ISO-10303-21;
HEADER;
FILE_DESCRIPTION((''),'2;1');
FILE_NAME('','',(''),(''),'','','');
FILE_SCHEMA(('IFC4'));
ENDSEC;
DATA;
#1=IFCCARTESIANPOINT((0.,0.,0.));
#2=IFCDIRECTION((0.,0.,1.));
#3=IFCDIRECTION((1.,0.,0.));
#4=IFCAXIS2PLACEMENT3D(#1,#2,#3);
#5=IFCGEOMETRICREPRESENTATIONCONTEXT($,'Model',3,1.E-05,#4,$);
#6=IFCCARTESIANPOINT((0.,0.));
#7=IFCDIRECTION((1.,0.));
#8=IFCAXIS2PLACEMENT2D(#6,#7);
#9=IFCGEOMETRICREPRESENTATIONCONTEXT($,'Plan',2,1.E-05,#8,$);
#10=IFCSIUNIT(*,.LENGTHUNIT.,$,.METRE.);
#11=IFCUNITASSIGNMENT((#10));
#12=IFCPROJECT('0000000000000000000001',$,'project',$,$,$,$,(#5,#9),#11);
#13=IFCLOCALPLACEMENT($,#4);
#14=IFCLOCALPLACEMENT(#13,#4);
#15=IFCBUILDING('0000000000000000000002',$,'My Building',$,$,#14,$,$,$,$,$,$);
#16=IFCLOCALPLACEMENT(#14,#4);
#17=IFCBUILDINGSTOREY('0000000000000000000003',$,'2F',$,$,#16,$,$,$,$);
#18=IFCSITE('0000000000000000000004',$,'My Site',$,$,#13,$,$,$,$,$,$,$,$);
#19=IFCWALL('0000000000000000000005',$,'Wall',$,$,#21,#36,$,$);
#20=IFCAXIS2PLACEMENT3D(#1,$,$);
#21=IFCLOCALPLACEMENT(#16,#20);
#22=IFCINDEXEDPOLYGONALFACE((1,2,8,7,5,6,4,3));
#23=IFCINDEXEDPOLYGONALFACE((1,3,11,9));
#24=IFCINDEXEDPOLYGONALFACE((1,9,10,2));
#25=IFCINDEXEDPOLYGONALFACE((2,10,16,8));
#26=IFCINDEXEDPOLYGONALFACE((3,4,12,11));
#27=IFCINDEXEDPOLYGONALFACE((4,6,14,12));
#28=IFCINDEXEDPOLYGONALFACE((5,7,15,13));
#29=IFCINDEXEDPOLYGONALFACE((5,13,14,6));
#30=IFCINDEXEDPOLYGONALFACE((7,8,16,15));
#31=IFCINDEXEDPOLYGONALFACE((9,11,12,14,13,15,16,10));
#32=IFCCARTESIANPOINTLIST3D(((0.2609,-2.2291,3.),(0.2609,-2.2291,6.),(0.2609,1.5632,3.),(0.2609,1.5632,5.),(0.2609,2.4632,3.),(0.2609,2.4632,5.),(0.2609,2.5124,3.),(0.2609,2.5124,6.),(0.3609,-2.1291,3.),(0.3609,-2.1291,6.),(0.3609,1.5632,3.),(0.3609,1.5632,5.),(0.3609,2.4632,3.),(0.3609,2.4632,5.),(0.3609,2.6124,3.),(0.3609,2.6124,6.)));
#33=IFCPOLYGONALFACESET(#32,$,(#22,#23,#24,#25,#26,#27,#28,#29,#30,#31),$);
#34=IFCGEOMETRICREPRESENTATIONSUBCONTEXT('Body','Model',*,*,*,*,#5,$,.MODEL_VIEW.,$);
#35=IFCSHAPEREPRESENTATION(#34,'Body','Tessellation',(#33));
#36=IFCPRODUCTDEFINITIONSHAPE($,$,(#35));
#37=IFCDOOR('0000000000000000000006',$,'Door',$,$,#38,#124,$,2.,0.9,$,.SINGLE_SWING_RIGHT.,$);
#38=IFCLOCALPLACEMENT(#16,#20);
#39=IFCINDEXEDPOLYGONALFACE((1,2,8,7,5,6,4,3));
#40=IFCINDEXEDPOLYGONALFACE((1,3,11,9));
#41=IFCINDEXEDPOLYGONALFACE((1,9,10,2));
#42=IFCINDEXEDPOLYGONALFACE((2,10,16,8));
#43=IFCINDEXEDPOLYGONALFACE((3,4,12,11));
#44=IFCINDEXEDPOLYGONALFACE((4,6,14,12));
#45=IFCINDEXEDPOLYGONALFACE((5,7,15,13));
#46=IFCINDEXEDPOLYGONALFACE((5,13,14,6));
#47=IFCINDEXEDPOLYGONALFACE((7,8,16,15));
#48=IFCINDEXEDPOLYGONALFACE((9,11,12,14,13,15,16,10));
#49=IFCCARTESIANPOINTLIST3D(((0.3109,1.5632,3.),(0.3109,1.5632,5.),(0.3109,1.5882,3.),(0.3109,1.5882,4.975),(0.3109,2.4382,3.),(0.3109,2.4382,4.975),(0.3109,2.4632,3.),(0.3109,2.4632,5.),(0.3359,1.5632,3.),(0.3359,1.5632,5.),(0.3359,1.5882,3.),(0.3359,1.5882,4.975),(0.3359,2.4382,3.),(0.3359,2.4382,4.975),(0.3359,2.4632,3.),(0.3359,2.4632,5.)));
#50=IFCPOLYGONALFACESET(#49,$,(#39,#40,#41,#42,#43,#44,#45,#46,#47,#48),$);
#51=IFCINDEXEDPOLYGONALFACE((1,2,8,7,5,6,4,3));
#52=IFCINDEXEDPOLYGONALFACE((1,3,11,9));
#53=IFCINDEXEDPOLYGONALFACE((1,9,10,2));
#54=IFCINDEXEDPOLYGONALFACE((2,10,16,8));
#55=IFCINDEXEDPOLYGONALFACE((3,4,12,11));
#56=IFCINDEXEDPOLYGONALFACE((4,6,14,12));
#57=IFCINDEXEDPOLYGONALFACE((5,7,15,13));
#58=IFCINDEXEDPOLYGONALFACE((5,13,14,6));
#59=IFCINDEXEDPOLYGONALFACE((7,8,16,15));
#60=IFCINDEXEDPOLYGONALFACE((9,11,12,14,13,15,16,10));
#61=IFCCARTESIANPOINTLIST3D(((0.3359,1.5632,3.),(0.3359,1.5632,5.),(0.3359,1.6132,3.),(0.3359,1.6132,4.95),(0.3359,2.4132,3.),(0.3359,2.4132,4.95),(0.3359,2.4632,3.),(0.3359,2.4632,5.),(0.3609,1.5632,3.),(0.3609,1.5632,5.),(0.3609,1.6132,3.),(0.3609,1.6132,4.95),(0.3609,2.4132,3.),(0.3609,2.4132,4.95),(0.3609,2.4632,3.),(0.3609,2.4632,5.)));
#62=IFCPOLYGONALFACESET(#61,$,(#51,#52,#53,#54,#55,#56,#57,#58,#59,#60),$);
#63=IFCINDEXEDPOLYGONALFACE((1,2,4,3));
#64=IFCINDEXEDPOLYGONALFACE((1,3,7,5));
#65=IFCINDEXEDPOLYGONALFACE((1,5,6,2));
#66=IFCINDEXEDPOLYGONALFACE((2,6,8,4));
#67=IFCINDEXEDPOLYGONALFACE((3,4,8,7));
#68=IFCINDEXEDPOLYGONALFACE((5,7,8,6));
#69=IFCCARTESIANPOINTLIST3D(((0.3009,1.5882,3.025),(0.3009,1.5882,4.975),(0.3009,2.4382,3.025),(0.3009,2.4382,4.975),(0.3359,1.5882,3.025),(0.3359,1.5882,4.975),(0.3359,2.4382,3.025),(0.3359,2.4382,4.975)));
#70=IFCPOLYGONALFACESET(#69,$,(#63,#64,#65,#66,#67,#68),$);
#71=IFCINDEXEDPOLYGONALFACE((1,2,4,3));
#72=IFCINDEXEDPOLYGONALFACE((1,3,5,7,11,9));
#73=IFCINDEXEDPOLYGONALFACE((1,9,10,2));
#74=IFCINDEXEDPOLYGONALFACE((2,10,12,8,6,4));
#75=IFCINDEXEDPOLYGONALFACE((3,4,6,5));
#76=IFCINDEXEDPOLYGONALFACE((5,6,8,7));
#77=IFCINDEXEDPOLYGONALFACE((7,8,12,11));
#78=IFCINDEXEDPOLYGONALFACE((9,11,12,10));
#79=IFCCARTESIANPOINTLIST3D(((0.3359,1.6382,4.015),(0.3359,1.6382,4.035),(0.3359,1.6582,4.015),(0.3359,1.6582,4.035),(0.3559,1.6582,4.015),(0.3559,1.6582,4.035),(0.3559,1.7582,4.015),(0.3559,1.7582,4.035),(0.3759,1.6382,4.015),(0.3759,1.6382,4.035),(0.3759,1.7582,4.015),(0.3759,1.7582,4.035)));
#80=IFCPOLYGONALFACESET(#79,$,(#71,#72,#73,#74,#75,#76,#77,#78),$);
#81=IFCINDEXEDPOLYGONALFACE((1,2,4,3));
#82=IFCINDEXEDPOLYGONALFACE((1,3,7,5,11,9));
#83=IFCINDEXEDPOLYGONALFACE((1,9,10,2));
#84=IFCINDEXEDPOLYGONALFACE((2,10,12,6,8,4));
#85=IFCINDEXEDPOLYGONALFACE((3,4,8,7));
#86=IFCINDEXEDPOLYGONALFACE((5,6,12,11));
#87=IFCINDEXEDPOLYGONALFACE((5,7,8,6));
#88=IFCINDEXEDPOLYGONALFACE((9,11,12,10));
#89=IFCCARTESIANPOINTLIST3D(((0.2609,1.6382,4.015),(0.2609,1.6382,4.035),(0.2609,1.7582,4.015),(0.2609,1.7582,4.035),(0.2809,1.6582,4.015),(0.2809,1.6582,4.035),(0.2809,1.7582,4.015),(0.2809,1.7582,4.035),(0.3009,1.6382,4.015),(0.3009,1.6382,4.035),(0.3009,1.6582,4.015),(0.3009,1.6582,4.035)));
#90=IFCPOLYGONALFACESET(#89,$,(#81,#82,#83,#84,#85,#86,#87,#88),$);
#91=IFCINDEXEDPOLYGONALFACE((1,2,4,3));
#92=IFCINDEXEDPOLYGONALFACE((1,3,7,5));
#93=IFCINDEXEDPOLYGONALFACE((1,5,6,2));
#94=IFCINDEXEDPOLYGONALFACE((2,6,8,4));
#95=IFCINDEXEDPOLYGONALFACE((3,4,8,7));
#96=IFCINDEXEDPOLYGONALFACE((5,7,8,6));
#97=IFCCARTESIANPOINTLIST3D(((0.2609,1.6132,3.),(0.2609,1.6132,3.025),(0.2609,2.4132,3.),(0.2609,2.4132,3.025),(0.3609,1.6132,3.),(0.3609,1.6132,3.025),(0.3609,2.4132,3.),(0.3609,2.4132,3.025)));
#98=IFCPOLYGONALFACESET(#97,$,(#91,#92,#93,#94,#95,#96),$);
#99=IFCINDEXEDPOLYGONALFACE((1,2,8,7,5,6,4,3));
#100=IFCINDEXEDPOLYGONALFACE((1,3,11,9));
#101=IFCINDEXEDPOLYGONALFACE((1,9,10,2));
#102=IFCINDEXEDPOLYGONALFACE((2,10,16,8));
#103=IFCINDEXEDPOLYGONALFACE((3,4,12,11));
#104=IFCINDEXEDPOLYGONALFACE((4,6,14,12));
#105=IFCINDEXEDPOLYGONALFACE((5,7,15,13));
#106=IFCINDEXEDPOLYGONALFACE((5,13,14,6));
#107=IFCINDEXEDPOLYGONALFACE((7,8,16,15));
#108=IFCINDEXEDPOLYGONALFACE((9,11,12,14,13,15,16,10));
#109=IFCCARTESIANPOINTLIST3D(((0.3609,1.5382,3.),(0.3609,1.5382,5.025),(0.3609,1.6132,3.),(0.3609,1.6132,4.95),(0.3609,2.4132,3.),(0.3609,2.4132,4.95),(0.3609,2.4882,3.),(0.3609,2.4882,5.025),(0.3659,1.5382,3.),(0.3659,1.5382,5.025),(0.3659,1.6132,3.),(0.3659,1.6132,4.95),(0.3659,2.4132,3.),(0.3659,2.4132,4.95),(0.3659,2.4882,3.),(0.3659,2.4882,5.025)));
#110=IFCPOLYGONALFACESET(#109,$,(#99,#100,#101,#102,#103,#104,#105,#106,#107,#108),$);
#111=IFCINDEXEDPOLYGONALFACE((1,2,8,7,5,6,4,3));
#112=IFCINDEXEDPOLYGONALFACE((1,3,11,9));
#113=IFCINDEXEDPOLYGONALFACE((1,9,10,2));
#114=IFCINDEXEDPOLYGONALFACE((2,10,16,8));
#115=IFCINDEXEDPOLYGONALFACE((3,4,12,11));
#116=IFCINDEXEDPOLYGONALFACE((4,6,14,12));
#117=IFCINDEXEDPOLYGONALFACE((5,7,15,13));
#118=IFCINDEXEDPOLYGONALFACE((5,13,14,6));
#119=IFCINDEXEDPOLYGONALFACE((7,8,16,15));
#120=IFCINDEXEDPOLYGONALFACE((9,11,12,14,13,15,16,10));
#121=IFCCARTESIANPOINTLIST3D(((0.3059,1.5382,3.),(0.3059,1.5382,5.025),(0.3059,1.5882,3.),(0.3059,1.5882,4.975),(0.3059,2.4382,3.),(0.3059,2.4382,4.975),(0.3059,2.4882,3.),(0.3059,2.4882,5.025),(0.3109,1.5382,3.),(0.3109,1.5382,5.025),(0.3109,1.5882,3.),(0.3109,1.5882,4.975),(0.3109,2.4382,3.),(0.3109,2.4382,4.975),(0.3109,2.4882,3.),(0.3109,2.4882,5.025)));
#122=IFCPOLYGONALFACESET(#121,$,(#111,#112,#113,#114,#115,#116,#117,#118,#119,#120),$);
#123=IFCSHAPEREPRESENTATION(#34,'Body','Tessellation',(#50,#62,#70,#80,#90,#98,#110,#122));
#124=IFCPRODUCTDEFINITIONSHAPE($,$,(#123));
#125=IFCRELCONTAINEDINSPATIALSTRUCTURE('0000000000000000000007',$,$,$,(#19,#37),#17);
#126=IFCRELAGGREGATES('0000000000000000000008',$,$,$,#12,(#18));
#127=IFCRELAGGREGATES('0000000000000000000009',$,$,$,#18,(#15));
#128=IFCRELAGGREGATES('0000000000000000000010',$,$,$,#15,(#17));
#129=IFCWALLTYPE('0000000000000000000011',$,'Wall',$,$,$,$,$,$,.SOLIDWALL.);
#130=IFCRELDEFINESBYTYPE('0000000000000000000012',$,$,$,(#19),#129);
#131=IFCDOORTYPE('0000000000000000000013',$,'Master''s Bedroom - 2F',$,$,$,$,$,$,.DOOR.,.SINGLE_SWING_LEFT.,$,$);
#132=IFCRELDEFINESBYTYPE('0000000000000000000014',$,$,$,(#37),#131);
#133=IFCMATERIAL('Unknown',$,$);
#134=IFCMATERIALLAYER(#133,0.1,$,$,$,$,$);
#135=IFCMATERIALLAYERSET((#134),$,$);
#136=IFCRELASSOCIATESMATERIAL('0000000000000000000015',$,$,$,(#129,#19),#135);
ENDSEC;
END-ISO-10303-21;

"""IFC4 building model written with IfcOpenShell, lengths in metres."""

from ifc_helpers import new_model, entity, si_unit, frame, origin_with_axes, origin_2d_with_axis, place, context, subcontext, project, spatial, line, indexed_curve, outline, extrude, shape, source, transform, mapped, material, layer, layer_set, layer_usage, type_object, type_shapes, element, fill, save


model = new_model("IFC4")

# Units and contexts
model_context = context("Model", 3, precision=1e-05, world=origin_with_axes())
plan_context = context("Plan", 2, precision=1e-05, world=origin_2d_with_axis())
body_context_1 = subcontext(model_context, "Body", "Model", "MODEL_VIEW")
body_context_2 = subcontext(plan_context, "Body", "Plan", "PLAN_VIEW")
ifc_project = project(units=[si_unit("LENGTHUNIT", "METRE")], contexts=[model_context, plan_context])

# Site, building, storey
site_placement = place(None, origin_with_axes())
site = spatial("IfcSite", under=ifc_project, at=site_placement, Name="My Site")
building_placement = place(site_placement, origin_with_axes())
building = spatial("IfcBuilding", under=site, at=building_placement, Name="My Building")
storey_placement = place(building_placement, origin_with_axes())
storey = spatial("IfcBuildingStorey", under=building, at=storey_placement, Name="2F")

# Shared definitions
ifc_material = material(Name="Unknown")
ifc_layer = layer(ifc_material, 0.1)
ifc_layer_set = layer_set([ifc_layer])
wall_type = type_object("IfcWallType", Name="Wall", PredefinedType="SOLIDWALL", material=ifc_layer_set)

# Wall, opening, door
ifc_layer_usage_1 = layer_usage(ifc_layer_set, "AXIS2", "POSITIVE", 0.0)
wall_1_placement = place(storey_placement, frame((0.2609, 2.5124, 3.0), z_axis=(0.0, 0.0, 1.0), x_axis=(0.0, -1.0, 0.0)))
wall_1 = element("IfcWall", 1, at=wall_1_placement, inside=storey, type_object=wall_type, material=ifc_layer_usage_1, Name="Wall", context=body_context_1, shape_type="SweptSolid", body=[
    extrude(outline(indexed_curve([(0.0, 0.0), (-0.1, 0.1), (4.6414, 0.1), (4.7414, 0.0)], segments=[line(1, 2, 3, 4, 1)])), origin_with_axes(), (0.0, 0.0, 1.0), 3.0),
])
shared_shape_1 = source(origin_with_axes(), body_context_1, "Body", "SweptSolid", [
    extrude(outline(indexed_curve([(0.0, 0.0), (0.9, 0.0), (0.9, 2.0), (0.0, 2.0)], segments=[line(1, 2, 3, 4, 1)])), frame((0.0, -0.6, 0.0), z_axis=(0.0, -1.0, 0.0), x_axis=(1.0, 0.0, 0.0)), (0.0, 0.0, -1.0), 1.2),
])
opening_1_placement = place(wall_1_placement, frame((0.9491, 0.1, 0.0), z_axis=(0.0, 0.0, 1.0), x_axis=(-1.0, 0.0, 0.0)))
opening_1 = element("IfcOpeningElement", 2, at=opening_1_placement, cuts=wall_1, PredefinedType="OPENING", context=body_context_1, shape_type="MappedRepresentation", body=[
    mapped(shared_shape_1, transform((0.0, 0.0, 0.0), x_axis=(1.0, 0.0, 0.0), y_axis=(0.0, 1.0, 0.0), z_axis=(0.0, 0.0, 1.0), scale=1.0)),
])
door_type_1 = type_object("IfcDoorType", Name="Master's Bedroom - 2F", OperationType="SINGLE_SWING_LEFT", PredefinedType="DOOR")
shared_shape_2 = source(origin_with_axes(), body_context_1, "Body", "SweptSolid", [
    extrude(outline(indexed_curve([(0.0, 0.0), (0.0, 2.0), (0.9, 2.0), (0.9, 0.0), (0.875, 0.0), (0.875, 1.975), (0.025, 1.975), (0.025, 0.0)], segments=[line(1, 2, 3, 4, 5, 6, 7, 8, 1)])), frame((0.0, 0.025, 0.0), z_axis=(0.0, -1.0, 0.0), x_axis=(1.0, 0.0, 0.0)), (0.0, 0.0, -1.0), 0.025),
    extrude(outline(indexed_curve([(0.0, 0.0), (0.0, 2.0), (0.9, 2.0), (0.9, 0.0), (0.85, 0.0), (0.85, 1.95), (0.05, 1.95), (0.05, 0.0)], segments=[line(1, 2, 3, 4, 5, 6, 7, 8, 1)])), frame((0.0, 0.0, 0.0), z_axis=(0.0, -1.0, 0.0), x_axis=(1.0, 0.0, 0.0)), (0.0, 0.0, -1.0), 0.025),
    extrude(outline(indexed_curve([(0.0, 0.0), (0.85, 0.0), (0.85, 0.035), (0.0, 0.035)], segments=[line(1, 2, 3, 4, 1)])), frame((0.025, 0.025, 0.025), z_axis=(0.0, 0.0, 1.0), x_axis=(1.0, 0.0, 0.0)), (0.0, 0.0, 1.0), 1.95),
    extrude(outline(indexed_curve([(0.0, 0.0), (0.0, -0.04), (0.12, -0.04), (0.12, -0.02), (0.02, -0.02), (0.02, 0.0)], segments=[line(1, 2, 3, 4, 5, 6, 1)])), frame((0.075, 0.025, 1.015), z_axis=(0.0, 0.0, 1.0), x_axis=(1.0, 0.0, 0.0)), (0.0, 0.0, 1.0), 0.02),
    extrude(outline(indexed_curve([(0.0, 0.0), (0.0, 0.04), (0.12, 0.04), (0.12, 0.02), (0.02, 0.02), (0.02, 0.0)], segments=[line(1, 2, 3, 4, 5, 6, 1)])), frame((0.075, 0.06, 1.015), z_axis=(0.0, 0.0, 1.0), x_axis=(1.0, 0.0, 0.0)), (0.0, 0.0, 1.0), 0.02),
    extrude(outline(indexed_curve([(0.0, 0.0), (0.8, 0.0), (0.8, 0.1), (0.0, 0.1)], segments=[line(1, 2, 3, 4, 1)])), frame((0.05, 0.0, 0.0), z_axis=(0.0, 0.0, 1.0), x_axis=(1.0, 0.0, 0.0)), (0.0, 0.0, 1.0), 0.025),
    extrude(outline(indexed_curve([(0.0, 0.0), (0.0, 2.025), (0.95, 2.025), (0.95, 0.0), (0.875, 0.0), (0.875, 1.95), (0.075, 1.95), (0.075, 0.0)], segments=[line(1, 2, 3, 4, 5, 6, 7, 8, 1)])), frame((-0.025, -0.005, 0.0), z_axis=(0.0, -1.0, 0.0), x_axis=(1.0, 0.0, 0.0)), (0.0, 0.0, -1.0), 0.005),
    extrude(outline(indexed_curve([(0.0, 0.0), (0.0, 2.025), (0.95, 2.025), (0.95, 0.0), (0.9, 0.0), (0.9, 1.975), (0.05, 1.975), (0.05, 0.0)], segments=[line(1, 2, 3, 4, 5, 6, 7, 8, 1)])), frame((-0.025, 0.05, 0.0), z_axis=(0.0, -1.0, 0.0), x_axis=(1.0, 0.0, 0.0)), (0.0, 0.0, -1.0), 0.005),
])
shared_shape_3 = source(origin_with_axes(), body_context_2, "Body", "Curve2D", [
    entity("IfcIndexedPolyCurve", entity("IfcCartesianPointList2D", [[0.0, 0.0], [0.0, 0.05], [0.025, 0.05], [0.025, 0.025], [0.05, 0.025], [0.05, 0.0]]), [entity("IfcLineIndex", [1, 2, 3, 4, 5, 6, 1])]),
    entity("IfcIndexedPolyCurve", entity("IfcCartesianPointList2D", [[0.9, 0.0], [0.9, 0.05], [0.875, 0.05], [0.875, 0.025], [0.85, 0.025], [0.85, 0.0]]), [entity("IfcLineIndex", [1, 2, 3, 4, 5, 6, 1])]),
    entity("IfcTrimmedCurve", entity("IfcEllipse", entity("IfcAxis2Placement2D", entity("IfcCartesianPoint", [0.84, 0.05]), entity("IfcDirection", [1.0, 0.0])), 0.815, 0.85), [entity("IfcCartesianPoint", [0.84, 0.9])], [entity("IfcCartesianPoint", [0.025, 0.05])], True, "CARTESIAN"),
    entity("IfcIndexedPolyCurve", entity("IfcCartesianPointList2D", [[0.875, 0.05], [0.84, 0.05], [0.84, 0.9], [0.875, 0.9]]), [entity("IfcLineIndex", [1, 2, 3, 4, 1])]),
])
type_shapes(door_type_1, [shared_shape_2, shared_shape_3])
door_1_placement = place(opening_1_placement, frame((0.0, 0.0, 0.0), z_axis=(0.0, 0.0, 1.0), x_axis=(1.0, 0.0, 0.0)))
door_1 = element("IfcDoor", 3, at=door_1_placement, inside=storey, type_object=door_type_1, Name="Door", OperationType="SINGLE_SWING_RIGHT", OverallHeight=2.0, OverallWidth=0.9, shapes=[
    shape(body_context_1, "Body", "MappedRepresentation", [mapped(shared_shape_2, transform((0.0, 0.0, 0.0), x_axis=(1.0, 0.0, 0.0), y_axis=(0.0, 1.0, 0.0), z_axis=(0.0, 0.0, 1.0), scale=1.0))]),
    shape(body_context_2, "Body", "MappedRepresentation", [mapped(shared_shape_3, transform((0.0, 0.0, 0.0), x_axis=(1.0, 0.0, 0.0), y_axis=(0.0, 1.0, 0.0), z_axis=(0.0, 0.0, 1.0), scale=1.0))]),
])
fill(opening_1, door_1)

save(model, "model.ifc")
